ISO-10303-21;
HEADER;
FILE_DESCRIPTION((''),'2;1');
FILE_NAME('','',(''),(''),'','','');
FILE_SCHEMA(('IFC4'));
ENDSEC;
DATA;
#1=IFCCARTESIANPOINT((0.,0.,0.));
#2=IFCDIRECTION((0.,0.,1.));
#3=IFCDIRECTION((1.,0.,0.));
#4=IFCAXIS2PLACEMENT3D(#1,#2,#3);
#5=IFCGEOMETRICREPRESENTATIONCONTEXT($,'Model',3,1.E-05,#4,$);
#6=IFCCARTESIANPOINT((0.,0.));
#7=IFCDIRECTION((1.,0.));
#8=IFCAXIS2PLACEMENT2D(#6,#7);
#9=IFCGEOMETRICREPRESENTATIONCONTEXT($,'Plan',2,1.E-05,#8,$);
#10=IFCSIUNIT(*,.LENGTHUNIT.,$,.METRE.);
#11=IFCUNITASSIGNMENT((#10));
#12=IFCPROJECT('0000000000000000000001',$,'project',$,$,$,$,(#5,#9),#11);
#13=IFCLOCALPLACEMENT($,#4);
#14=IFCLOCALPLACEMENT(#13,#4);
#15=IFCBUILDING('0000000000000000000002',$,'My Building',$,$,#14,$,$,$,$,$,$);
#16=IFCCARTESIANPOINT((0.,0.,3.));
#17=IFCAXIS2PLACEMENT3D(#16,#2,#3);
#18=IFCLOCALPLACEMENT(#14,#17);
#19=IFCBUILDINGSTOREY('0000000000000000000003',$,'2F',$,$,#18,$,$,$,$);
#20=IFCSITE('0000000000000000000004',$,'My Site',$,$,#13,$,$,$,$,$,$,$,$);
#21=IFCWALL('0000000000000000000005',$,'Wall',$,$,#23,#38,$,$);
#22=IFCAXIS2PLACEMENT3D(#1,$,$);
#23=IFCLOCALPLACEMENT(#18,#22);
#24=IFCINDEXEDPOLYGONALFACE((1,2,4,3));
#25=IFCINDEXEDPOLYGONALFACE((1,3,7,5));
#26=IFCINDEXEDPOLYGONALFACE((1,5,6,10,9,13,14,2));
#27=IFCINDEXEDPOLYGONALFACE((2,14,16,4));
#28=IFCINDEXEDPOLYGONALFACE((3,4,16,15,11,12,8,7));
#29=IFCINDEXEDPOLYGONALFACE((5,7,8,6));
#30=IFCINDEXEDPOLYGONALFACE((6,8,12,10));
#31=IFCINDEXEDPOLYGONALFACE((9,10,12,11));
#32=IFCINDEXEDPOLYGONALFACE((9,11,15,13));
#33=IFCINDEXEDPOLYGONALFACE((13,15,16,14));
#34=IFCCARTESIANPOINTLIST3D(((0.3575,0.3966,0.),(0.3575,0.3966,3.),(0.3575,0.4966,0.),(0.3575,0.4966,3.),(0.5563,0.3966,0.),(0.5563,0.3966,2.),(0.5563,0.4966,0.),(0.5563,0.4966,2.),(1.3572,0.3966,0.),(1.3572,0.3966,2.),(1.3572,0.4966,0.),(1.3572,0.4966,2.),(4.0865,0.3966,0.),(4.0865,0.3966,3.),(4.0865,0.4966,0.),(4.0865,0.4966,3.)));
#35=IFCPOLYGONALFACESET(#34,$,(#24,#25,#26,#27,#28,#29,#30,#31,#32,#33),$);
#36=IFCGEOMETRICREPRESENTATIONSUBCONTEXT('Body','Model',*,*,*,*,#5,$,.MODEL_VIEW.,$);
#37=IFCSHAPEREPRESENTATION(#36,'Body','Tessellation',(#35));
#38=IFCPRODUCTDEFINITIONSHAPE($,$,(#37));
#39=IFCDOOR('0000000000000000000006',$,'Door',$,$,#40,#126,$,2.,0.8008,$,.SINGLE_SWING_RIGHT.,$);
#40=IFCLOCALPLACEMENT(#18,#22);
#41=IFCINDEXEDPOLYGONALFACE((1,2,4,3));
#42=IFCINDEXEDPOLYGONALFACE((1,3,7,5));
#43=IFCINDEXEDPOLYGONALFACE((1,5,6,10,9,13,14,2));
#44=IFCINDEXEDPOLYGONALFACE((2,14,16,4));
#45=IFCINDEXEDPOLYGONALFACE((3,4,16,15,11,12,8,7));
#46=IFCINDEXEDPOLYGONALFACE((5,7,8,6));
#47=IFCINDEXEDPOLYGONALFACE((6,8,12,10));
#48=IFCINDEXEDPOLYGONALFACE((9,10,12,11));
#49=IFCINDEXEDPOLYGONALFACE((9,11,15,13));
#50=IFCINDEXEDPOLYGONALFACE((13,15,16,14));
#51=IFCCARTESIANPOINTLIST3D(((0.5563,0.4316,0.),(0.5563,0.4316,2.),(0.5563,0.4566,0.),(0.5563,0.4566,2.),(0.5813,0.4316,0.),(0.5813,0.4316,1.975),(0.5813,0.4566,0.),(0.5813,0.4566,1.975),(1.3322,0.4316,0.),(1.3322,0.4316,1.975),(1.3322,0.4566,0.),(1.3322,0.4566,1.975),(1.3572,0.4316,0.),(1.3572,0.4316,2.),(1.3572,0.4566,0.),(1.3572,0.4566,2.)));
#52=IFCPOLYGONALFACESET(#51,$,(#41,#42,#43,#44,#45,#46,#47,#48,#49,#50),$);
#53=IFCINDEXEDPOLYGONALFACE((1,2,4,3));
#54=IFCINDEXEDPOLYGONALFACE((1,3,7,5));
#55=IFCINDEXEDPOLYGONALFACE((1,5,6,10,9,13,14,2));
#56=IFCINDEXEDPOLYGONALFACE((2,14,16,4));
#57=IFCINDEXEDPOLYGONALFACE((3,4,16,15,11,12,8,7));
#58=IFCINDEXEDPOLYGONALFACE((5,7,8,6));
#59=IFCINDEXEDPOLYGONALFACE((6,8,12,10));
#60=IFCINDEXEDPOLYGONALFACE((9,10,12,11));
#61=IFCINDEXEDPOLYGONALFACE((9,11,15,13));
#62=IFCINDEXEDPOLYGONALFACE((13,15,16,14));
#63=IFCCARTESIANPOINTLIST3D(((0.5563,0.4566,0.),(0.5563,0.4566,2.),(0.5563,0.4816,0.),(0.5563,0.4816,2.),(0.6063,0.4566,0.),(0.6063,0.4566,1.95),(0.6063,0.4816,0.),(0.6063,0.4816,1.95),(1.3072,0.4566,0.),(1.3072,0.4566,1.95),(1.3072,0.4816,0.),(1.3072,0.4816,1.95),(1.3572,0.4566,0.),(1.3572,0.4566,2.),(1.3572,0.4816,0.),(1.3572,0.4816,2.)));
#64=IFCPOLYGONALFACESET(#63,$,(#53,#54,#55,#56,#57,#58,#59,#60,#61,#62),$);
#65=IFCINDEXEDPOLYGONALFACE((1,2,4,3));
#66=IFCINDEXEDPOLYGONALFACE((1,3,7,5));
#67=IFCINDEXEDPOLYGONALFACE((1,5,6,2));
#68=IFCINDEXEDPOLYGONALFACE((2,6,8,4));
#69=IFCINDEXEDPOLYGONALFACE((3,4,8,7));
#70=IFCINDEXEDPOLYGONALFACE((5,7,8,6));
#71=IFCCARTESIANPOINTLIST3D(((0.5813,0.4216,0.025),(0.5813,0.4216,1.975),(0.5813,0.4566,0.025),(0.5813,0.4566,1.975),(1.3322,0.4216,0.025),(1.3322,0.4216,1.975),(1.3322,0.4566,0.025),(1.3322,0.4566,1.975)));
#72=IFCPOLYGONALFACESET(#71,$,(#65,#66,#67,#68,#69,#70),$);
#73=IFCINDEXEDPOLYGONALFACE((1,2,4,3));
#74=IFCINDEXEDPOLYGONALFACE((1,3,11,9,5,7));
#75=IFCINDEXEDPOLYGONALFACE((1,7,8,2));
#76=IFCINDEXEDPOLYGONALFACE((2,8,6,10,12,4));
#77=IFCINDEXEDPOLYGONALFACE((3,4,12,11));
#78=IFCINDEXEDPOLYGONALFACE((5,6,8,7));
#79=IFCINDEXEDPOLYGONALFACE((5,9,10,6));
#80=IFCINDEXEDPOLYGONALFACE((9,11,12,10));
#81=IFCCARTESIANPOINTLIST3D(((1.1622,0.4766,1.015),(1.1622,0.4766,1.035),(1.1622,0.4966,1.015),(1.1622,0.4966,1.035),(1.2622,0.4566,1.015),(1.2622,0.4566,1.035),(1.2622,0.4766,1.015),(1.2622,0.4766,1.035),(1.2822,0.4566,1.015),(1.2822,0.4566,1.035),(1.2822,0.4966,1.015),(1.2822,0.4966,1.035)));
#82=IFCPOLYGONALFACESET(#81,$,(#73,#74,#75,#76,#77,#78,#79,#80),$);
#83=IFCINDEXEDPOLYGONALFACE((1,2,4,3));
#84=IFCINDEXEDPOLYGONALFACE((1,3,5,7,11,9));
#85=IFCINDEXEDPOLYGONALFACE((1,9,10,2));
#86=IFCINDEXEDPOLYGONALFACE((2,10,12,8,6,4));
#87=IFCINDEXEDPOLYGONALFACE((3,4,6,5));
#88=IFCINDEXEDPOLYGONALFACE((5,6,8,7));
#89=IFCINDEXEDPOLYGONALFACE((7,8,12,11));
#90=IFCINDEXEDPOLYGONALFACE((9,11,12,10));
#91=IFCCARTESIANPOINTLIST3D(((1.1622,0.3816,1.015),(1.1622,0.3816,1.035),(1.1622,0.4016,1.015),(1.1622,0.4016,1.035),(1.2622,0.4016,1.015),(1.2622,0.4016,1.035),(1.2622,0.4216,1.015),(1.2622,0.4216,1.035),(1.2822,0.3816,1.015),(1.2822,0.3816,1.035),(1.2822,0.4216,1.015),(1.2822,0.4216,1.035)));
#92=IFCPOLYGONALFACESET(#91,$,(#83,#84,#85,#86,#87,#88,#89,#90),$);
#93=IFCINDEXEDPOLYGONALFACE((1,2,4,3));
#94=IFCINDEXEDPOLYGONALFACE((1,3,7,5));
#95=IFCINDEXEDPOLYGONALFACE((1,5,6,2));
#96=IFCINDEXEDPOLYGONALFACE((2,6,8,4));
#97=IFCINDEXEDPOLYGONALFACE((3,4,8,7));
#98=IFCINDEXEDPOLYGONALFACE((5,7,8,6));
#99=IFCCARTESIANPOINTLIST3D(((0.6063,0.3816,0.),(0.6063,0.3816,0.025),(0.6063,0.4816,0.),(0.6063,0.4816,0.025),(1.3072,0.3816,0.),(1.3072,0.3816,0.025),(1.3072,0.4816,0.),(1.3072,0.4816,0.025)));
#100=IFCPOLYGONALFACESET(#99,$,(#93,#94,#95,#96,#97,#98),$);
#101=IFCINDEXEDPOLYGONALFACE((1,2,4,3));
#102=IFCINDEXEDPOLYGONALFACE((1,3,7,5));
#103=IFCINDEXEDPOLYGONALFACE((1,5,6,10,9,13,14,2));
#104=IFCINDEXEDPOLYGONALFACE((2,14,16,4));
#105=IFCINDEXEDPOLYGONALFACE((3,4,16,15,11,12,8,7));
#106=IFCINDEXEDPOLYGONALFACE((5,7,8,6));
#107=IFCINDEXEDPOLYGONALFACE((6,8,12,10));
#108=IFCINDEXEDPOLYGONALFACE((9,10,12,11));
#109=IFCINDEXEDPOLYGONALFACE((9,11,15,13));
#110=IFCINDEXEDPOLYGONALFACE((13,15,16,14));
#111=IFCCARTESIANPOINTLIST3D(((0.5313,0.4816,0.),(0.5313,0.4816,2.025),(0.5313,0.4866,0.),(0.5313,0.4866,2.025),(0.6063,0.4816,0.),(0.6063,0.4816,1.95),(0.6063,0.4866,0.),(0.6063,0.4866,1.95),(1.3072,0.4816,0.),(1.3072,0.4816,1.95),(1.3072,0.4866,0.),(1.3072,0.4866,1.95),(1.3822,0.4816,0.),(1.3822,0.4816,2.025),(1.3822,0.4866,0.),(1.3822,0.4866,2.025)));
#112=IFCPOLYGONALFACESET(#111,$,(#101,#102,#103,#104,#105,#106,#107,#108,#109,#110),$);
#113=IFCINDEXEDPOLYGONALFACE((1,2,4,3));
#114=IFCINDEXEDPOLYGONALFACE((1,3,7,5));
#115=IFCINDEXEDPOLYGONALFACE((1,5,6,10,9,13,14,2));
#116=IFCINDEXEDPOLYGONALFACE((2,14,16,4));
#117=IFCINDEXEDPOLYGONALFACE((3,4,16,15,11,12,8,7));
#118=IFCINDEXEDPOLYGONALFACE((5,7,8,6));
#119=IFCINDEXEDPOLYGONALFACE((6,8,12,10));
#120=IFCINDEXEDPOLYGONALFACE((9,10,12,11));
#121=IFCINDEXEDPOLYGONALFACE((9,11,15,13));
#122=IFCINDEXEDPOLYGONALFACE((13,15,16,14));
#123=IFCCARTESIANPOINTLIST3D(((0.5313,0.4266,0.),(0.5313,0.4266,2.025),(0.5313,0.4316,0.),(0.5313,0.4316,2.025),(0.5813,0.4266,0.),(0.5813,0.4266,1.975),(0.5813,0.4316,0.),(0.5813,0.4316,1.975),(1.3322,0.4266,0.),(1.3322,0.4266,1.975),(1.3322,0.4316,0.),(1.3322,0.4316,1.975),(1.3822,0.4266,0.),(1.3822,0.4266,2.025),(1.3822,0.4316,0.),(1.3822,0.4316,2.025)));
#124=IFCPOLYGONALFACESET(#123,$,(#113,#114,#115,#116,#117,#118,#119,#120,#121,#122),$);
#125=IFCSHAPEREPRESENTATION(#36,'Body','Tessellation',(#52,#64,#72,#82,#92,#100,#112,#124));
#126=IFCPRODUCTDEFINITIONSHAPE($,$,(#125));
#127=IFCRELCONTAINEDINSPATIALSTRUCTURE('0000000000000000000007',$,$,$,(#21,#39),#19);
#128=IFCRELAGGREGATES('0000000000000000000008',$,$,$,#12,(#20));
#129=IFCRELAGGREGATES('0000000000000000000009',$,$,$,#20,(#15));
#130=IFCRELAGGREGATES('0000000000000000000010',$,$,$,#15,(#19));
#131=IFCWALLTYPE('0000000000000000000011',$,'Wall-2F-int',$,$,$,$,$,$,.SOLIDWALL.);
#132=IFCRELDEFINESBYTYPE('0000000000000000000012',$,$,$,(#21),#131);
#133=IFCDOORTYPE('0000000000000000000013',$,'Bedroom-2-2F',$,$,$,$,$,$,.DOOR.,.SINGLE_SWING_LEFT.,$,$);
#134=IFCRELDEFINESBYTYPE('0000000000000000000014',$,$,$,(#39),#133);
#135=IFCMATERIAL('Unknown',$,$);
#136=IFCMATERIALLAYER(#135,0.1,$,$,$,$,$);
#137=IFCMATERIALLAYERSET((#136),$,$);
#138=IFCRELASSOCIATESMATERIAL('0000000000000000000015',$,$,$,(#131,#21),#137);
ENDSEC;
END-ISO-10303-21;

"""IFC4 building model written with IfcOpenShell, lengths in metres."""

from ifc_helpers import new_model, entity, si_unit, frame, origin_with_axes, origin_2d_with_axis, place, context, subcontext, project, spatial, line, indexed_curve, outline, extrude, shape, source, transform, mapped, material, layer, layer_set, layer_usage, type_object, type_shapes, element, fill, save


model = new_model("IFC4")

# Units and contexts
model_context = context("Model", 3, precision=1e-05, world=origin_with_axes())
plan_context = context("Plan", 2, precision=1e-05, world=origin_2d_with_axis())
body_context_1 = subcontext(model_context, "Body", "Model", "MODEL_VIEW")
body_context_2 = subcontext(plan_context, "Body", "Plan", "PLAN_VIEW")
ifc_project = project(units=[si_unit("LENGTHUNIT", "METRE")], contexts=[model_context, plan_context])

# Site, building, storey
site_placement = place(None, origin_with_axes())
site = spatial("IfcSite", under=ifc_project, at=site_placement, Name="My Site")
building_placement = place(site_placement, origin_with_axes())
building = spatial("IfcBuilding", under=site, at=building_placement, Name="My Building")
storey_placement = place(building_placement, frame((0.0, 0.0, 3.0), z_axis=(0.0, 0.0, 1.0), x_axis=(1.0, 0.0, 0.0)))
storey = spatial("IfcBuildingStorey", under=building, at=storey_placement, Name="2F")

# Shared definitions
ifc_material = material(Name="Unknown")

# Shared definitions
ifc_layer_1 = layer(ifc_material, 0.1)
ifc_layer_set_1 = layer_set([ifc_layer_1])
wall_type_1 = type_object("IfcWallType", Name="Wall-2F-int", PredefinedType="SOLIDWALL", material=ifc_layer_set_1)

# Wall, opening, door
ifc_layer_usage_1 = layer_usage(ifc_layer_set_1, "AXIS2", "POSITIVE", 0.0)
wall_1_placement = place(storey_placement, frame((0.3575, 0.3966, 0.0), z_axis=(0.0, 0.0, 1.0), x_axis=(1.0, -0.000006, 0.0)))
wall_1 = element("IfcWall", 1, at=wall_1_placement, inside=storey, type_object=wall_type_1, material=ifc_layer_usage_1, Name="Wall", context=body_context_1, shape_type="SweptSolid", body=[
    extrude(outline(indexed_curve([(0.0, 0.0), (0.0, 0.1), (3.729, 0.1), (3.729, 0.0)], segments=[line(1, 2, 3, 4, 1)])), origin_with_axes(), (0.0, 0.0, 1.0), 3.0),
])
shared_shape_1 = source(origin_with_axes(), body_context_1, "Body", "SweptSolid", [
    extrude(outline(indexed_curve([(0.0, 0.0), (0.8008, 0.0), (0.8008, 2.0), (0.0, 2.0)], segments=[line(1, 2, 3, 4, 1)])), frame((0.0, -0.6, 0.0), z_axis=(0.0, -1.0, 0.0), x_axis=(1.0, 0.0, 0.0)), (0.0, 0.0, -1.0), 1.2),
])
opening_1_placement = place(wall_1_placement, frame((0.9997, 0.085, 0.0), z_axis=(0.0, 0.0, 1.0), x_axis=(-1.0, 0.0, 0.0)))
opening_1 = element("IfcOpeningElement", 2, at=opening_1_placement, cuts=wall_1, PredefinedType="OPENING", context=body_context_1, shape_type="MappedRepresentation", body=[
    mapped(shared_shape_1, transform((0.0, 0.0, 0.0), x_axis=(1.0, 0.0, 0.0), y_axis=(0.0, 1.0, 0.0), z_axis=(0.0, 0.0, 1.0), scale=1.0)),
])
door_type_1 = type_object("IfcDoorType", Name="Bedroom-2-2F", OperationType="SINGLE_SWING_LEFT", PredefinedType="DOOR")
shared_shape_2 = source(origin_with_axes(), body_context_1, "Body", "SweptSolid", [
    extrude(outline(indexed_curve([(0.0, 0.0), (0.0, 2.0), (0.8008, 2.0), (0.8008, 0.0), (0.7758, 0.0), (0.7758, 1.975), (0.025, 1.975), (0.025, 0.0)], segments=[line(1, 2, 3, 4, 5, 6, 7, 8, 1)])), frame((0.0, 0.025, 0.0), z_axis=(0.0, -1.0, 0.0), x_axis=(1.0, 0.0, 0.0)), (0.0, 0.0, -1.0), 0.025),
    extrude(outline(indexed_curve([(0.0, 0.0), (0.0, 2.0), (0.8008, 2.0), (0.8008, 0.0), (0.7508, 0.0), (0.7508, 1.95), (0.05, 1.95), (0.05, 0.0)], segments=[line(1, 2, 3, 4, 5, 6, 7, 8, 1)])), frame((0.0, 0.0, 0.0), z_axis=(0.0, -1.0, 0.0), x_axis=(1.0, 0.0, 0.0)), (0.0, 0.0, -1.0), 0.025),
    extrude(outline(indexed_curve([(0.0, 0.0), (0.7508, 0.0), (0.7508, 0.035), (0.0, 0.035)], segments=[line(1, 2, 3, 4, 1)])), frame((0.025, 0.025, 0.025), z_axis=(0.0, 0.0, 1.0), x_axis=(1.0, 0.0, 0.0)), (0.0, 0.0, 1.0), 1.95),
    extrude(outline(indexed_curve([(0.0, 0.0), (0.0, -0.04), (0.12, -0.04), (0.12, -0.02), (0.02, -0.02), (0.02, 0.0)], segments=[line(1, 2, 3, 4, 5, 6, 1)])), frame((0.075, 0.025, 1.015), z_axis=(0.0, 0.0, 1.0), x_axis=(1.0, 0.0, 0.0)), (0.0, 0.0, 1.0), 0.02),
    extrude(outline(indexed_curve([(0.0, 0.0), (0.0, 0.04), (0.12, 0.04), (0.12, 0.02), (0.02, 0.02), (0.02, 0.0)], segments=[line(1, 2, 3, 4, 5, 6, 1)])), frame((0.075, 0.06, 1.015), z_axis=(0.0, 0.0, 1.0), x_axis=(1.0, 0.0, 0.0)), (0.0, 0.0, 1.0), 0.02),
    extrude(outline(indexed_curve([(0.0, 0.0), (0.7008, 0.0), (0.7008, 0.1), (0.0, 0.1)], segments=[line(1, 2, 3, 4, 1)])), frame((0.05, 0.0, 0.0), z_axis=(0.0, 0.0, 1.0), x_axis=(1.0, 0.0, 0.0)), (0.0, 0.0, 1.0), 0.025),
    extrude(outline(indexed_curve([(0.0, 0.0), (0.0, 2.025), (0.8508, 2.025), (0.8508, 0.0), (0.7758, 0.0), (0.7758, 1.95), (0.075, 1.95), (0.075, 0.0)], segments=[line(1, 2, 3, 4, 5, 6, 7, 8, 1)])), frame((-0.025, -0.005, 0.0), z_axis=(0.0, -1.0, 0.0), x_axis=(1.0, 0.0, 0.0)), (0.0, 0.0, -1.0), 0.005),
    extrude(outline(indexed_curve([(0.0, 0.0), (0.0, 2.025), (0.8508, 2.025), (0.8508, 0.0), (0.8008, 0.0), (0.8008, 1.975), (0.05, 1.975), (0.05, 0.0)], segments=[line(1, 2, 3, 4, 5, 6, 7, 8, 1)])), frame((-0.025, 0.05, 0.0), z_axis=(0.0, -1.0, 0.0), x_axis=(1.0, 0.0, 0.0)), (0.0, 0.0, -1.0), 0.005),
])
shared_shape_3 = source(origin_with_axes(), body_context_2, "Body", "Curve2D", [
    entity("IfcIndexedPolyCurve", entity("IfcCartesianPointList2D", [[0.0, 0.0], [0.0, 0.05], [0.025, 0.05], [0.025, 0.025], [0.05, 0.025], [0.05, 0.0]]), [entity("IfcLineIndex", [1, 2, 3, 4, 5, 6, 1])]),
    entity("IfcIndexedPolyCurve", entity("IfcCartesianPointList2D", [[0.8008, 0.0], [0.8008, 0.05], [0.7758, 0.05], [0.7758, 0.025], [0.7508, 0.025], [0.7508, 0.0]]), [entity("IfcLineIndex", [1, 2, 3, 4, 5, 6, 1])]),
    entity("IfcTrimmedCurve", entity("IfcEllipse", entity("IfcAxis2Placement2D", entity("IfcCartesianPoint", [0.7408, 0.05]), entity("IfcDirection", [1.0, 0.0])), 0.7158, 0.7508), [entity("IfcCartesianPoint", [0.7408, 0.8008])], [entity("IfcCartesianPoint", [0.025, 0.05])], True, "CARTESIAN"),
    entity("IfcIndexedPolyCurve", entity("IfcCartesianPointList2D", [[0.7758, 0.05], [0.7408, 0.05], [0.7408, 0.8008], [0.7758, 0.8008]]), [entity("IfcLineIndex", [1, 2, 3, 4, 1])]),
])
type_shapes(door_type_1, [shared_shape_2, shared_shape_3])
door_1_placement = place(opening_1_placement, origin_with_axes())
door_1 = element("IfcDoor", 3, at=door_1_placement, inside=storey, type_object=door_type_1, Name="Door", OperationType="SINGLE_SWING_RIGHT", OverallHeight=2.0, OverallWidth=0.8008, shapes=[
    shape(body_context_1, "Body", "MappedRepresentation", [mapped(shared_shape_2, transform((0.0, 0.0, 0.0), x_axis=(1.0, 0.0, 0.0), y_axis=(0.0, 1.0, 0.0), z_axis=(0.0, 0.0, 1.0), scale=1.0))]),
    shape(body_context_2, "Body", "MappedRepresentation", [mapped(shared_shape_3, transform((0.0, 0.0, 0.0), x_axis=(1.0, 0.0, 0.0), y_axis=(0.0, 1.0, 0.0), z_axis=(0.0, 0.0, 1.0), scale=1.0))]),
])
fill(opening_1, door_1)

save(model, "model.ifc")
